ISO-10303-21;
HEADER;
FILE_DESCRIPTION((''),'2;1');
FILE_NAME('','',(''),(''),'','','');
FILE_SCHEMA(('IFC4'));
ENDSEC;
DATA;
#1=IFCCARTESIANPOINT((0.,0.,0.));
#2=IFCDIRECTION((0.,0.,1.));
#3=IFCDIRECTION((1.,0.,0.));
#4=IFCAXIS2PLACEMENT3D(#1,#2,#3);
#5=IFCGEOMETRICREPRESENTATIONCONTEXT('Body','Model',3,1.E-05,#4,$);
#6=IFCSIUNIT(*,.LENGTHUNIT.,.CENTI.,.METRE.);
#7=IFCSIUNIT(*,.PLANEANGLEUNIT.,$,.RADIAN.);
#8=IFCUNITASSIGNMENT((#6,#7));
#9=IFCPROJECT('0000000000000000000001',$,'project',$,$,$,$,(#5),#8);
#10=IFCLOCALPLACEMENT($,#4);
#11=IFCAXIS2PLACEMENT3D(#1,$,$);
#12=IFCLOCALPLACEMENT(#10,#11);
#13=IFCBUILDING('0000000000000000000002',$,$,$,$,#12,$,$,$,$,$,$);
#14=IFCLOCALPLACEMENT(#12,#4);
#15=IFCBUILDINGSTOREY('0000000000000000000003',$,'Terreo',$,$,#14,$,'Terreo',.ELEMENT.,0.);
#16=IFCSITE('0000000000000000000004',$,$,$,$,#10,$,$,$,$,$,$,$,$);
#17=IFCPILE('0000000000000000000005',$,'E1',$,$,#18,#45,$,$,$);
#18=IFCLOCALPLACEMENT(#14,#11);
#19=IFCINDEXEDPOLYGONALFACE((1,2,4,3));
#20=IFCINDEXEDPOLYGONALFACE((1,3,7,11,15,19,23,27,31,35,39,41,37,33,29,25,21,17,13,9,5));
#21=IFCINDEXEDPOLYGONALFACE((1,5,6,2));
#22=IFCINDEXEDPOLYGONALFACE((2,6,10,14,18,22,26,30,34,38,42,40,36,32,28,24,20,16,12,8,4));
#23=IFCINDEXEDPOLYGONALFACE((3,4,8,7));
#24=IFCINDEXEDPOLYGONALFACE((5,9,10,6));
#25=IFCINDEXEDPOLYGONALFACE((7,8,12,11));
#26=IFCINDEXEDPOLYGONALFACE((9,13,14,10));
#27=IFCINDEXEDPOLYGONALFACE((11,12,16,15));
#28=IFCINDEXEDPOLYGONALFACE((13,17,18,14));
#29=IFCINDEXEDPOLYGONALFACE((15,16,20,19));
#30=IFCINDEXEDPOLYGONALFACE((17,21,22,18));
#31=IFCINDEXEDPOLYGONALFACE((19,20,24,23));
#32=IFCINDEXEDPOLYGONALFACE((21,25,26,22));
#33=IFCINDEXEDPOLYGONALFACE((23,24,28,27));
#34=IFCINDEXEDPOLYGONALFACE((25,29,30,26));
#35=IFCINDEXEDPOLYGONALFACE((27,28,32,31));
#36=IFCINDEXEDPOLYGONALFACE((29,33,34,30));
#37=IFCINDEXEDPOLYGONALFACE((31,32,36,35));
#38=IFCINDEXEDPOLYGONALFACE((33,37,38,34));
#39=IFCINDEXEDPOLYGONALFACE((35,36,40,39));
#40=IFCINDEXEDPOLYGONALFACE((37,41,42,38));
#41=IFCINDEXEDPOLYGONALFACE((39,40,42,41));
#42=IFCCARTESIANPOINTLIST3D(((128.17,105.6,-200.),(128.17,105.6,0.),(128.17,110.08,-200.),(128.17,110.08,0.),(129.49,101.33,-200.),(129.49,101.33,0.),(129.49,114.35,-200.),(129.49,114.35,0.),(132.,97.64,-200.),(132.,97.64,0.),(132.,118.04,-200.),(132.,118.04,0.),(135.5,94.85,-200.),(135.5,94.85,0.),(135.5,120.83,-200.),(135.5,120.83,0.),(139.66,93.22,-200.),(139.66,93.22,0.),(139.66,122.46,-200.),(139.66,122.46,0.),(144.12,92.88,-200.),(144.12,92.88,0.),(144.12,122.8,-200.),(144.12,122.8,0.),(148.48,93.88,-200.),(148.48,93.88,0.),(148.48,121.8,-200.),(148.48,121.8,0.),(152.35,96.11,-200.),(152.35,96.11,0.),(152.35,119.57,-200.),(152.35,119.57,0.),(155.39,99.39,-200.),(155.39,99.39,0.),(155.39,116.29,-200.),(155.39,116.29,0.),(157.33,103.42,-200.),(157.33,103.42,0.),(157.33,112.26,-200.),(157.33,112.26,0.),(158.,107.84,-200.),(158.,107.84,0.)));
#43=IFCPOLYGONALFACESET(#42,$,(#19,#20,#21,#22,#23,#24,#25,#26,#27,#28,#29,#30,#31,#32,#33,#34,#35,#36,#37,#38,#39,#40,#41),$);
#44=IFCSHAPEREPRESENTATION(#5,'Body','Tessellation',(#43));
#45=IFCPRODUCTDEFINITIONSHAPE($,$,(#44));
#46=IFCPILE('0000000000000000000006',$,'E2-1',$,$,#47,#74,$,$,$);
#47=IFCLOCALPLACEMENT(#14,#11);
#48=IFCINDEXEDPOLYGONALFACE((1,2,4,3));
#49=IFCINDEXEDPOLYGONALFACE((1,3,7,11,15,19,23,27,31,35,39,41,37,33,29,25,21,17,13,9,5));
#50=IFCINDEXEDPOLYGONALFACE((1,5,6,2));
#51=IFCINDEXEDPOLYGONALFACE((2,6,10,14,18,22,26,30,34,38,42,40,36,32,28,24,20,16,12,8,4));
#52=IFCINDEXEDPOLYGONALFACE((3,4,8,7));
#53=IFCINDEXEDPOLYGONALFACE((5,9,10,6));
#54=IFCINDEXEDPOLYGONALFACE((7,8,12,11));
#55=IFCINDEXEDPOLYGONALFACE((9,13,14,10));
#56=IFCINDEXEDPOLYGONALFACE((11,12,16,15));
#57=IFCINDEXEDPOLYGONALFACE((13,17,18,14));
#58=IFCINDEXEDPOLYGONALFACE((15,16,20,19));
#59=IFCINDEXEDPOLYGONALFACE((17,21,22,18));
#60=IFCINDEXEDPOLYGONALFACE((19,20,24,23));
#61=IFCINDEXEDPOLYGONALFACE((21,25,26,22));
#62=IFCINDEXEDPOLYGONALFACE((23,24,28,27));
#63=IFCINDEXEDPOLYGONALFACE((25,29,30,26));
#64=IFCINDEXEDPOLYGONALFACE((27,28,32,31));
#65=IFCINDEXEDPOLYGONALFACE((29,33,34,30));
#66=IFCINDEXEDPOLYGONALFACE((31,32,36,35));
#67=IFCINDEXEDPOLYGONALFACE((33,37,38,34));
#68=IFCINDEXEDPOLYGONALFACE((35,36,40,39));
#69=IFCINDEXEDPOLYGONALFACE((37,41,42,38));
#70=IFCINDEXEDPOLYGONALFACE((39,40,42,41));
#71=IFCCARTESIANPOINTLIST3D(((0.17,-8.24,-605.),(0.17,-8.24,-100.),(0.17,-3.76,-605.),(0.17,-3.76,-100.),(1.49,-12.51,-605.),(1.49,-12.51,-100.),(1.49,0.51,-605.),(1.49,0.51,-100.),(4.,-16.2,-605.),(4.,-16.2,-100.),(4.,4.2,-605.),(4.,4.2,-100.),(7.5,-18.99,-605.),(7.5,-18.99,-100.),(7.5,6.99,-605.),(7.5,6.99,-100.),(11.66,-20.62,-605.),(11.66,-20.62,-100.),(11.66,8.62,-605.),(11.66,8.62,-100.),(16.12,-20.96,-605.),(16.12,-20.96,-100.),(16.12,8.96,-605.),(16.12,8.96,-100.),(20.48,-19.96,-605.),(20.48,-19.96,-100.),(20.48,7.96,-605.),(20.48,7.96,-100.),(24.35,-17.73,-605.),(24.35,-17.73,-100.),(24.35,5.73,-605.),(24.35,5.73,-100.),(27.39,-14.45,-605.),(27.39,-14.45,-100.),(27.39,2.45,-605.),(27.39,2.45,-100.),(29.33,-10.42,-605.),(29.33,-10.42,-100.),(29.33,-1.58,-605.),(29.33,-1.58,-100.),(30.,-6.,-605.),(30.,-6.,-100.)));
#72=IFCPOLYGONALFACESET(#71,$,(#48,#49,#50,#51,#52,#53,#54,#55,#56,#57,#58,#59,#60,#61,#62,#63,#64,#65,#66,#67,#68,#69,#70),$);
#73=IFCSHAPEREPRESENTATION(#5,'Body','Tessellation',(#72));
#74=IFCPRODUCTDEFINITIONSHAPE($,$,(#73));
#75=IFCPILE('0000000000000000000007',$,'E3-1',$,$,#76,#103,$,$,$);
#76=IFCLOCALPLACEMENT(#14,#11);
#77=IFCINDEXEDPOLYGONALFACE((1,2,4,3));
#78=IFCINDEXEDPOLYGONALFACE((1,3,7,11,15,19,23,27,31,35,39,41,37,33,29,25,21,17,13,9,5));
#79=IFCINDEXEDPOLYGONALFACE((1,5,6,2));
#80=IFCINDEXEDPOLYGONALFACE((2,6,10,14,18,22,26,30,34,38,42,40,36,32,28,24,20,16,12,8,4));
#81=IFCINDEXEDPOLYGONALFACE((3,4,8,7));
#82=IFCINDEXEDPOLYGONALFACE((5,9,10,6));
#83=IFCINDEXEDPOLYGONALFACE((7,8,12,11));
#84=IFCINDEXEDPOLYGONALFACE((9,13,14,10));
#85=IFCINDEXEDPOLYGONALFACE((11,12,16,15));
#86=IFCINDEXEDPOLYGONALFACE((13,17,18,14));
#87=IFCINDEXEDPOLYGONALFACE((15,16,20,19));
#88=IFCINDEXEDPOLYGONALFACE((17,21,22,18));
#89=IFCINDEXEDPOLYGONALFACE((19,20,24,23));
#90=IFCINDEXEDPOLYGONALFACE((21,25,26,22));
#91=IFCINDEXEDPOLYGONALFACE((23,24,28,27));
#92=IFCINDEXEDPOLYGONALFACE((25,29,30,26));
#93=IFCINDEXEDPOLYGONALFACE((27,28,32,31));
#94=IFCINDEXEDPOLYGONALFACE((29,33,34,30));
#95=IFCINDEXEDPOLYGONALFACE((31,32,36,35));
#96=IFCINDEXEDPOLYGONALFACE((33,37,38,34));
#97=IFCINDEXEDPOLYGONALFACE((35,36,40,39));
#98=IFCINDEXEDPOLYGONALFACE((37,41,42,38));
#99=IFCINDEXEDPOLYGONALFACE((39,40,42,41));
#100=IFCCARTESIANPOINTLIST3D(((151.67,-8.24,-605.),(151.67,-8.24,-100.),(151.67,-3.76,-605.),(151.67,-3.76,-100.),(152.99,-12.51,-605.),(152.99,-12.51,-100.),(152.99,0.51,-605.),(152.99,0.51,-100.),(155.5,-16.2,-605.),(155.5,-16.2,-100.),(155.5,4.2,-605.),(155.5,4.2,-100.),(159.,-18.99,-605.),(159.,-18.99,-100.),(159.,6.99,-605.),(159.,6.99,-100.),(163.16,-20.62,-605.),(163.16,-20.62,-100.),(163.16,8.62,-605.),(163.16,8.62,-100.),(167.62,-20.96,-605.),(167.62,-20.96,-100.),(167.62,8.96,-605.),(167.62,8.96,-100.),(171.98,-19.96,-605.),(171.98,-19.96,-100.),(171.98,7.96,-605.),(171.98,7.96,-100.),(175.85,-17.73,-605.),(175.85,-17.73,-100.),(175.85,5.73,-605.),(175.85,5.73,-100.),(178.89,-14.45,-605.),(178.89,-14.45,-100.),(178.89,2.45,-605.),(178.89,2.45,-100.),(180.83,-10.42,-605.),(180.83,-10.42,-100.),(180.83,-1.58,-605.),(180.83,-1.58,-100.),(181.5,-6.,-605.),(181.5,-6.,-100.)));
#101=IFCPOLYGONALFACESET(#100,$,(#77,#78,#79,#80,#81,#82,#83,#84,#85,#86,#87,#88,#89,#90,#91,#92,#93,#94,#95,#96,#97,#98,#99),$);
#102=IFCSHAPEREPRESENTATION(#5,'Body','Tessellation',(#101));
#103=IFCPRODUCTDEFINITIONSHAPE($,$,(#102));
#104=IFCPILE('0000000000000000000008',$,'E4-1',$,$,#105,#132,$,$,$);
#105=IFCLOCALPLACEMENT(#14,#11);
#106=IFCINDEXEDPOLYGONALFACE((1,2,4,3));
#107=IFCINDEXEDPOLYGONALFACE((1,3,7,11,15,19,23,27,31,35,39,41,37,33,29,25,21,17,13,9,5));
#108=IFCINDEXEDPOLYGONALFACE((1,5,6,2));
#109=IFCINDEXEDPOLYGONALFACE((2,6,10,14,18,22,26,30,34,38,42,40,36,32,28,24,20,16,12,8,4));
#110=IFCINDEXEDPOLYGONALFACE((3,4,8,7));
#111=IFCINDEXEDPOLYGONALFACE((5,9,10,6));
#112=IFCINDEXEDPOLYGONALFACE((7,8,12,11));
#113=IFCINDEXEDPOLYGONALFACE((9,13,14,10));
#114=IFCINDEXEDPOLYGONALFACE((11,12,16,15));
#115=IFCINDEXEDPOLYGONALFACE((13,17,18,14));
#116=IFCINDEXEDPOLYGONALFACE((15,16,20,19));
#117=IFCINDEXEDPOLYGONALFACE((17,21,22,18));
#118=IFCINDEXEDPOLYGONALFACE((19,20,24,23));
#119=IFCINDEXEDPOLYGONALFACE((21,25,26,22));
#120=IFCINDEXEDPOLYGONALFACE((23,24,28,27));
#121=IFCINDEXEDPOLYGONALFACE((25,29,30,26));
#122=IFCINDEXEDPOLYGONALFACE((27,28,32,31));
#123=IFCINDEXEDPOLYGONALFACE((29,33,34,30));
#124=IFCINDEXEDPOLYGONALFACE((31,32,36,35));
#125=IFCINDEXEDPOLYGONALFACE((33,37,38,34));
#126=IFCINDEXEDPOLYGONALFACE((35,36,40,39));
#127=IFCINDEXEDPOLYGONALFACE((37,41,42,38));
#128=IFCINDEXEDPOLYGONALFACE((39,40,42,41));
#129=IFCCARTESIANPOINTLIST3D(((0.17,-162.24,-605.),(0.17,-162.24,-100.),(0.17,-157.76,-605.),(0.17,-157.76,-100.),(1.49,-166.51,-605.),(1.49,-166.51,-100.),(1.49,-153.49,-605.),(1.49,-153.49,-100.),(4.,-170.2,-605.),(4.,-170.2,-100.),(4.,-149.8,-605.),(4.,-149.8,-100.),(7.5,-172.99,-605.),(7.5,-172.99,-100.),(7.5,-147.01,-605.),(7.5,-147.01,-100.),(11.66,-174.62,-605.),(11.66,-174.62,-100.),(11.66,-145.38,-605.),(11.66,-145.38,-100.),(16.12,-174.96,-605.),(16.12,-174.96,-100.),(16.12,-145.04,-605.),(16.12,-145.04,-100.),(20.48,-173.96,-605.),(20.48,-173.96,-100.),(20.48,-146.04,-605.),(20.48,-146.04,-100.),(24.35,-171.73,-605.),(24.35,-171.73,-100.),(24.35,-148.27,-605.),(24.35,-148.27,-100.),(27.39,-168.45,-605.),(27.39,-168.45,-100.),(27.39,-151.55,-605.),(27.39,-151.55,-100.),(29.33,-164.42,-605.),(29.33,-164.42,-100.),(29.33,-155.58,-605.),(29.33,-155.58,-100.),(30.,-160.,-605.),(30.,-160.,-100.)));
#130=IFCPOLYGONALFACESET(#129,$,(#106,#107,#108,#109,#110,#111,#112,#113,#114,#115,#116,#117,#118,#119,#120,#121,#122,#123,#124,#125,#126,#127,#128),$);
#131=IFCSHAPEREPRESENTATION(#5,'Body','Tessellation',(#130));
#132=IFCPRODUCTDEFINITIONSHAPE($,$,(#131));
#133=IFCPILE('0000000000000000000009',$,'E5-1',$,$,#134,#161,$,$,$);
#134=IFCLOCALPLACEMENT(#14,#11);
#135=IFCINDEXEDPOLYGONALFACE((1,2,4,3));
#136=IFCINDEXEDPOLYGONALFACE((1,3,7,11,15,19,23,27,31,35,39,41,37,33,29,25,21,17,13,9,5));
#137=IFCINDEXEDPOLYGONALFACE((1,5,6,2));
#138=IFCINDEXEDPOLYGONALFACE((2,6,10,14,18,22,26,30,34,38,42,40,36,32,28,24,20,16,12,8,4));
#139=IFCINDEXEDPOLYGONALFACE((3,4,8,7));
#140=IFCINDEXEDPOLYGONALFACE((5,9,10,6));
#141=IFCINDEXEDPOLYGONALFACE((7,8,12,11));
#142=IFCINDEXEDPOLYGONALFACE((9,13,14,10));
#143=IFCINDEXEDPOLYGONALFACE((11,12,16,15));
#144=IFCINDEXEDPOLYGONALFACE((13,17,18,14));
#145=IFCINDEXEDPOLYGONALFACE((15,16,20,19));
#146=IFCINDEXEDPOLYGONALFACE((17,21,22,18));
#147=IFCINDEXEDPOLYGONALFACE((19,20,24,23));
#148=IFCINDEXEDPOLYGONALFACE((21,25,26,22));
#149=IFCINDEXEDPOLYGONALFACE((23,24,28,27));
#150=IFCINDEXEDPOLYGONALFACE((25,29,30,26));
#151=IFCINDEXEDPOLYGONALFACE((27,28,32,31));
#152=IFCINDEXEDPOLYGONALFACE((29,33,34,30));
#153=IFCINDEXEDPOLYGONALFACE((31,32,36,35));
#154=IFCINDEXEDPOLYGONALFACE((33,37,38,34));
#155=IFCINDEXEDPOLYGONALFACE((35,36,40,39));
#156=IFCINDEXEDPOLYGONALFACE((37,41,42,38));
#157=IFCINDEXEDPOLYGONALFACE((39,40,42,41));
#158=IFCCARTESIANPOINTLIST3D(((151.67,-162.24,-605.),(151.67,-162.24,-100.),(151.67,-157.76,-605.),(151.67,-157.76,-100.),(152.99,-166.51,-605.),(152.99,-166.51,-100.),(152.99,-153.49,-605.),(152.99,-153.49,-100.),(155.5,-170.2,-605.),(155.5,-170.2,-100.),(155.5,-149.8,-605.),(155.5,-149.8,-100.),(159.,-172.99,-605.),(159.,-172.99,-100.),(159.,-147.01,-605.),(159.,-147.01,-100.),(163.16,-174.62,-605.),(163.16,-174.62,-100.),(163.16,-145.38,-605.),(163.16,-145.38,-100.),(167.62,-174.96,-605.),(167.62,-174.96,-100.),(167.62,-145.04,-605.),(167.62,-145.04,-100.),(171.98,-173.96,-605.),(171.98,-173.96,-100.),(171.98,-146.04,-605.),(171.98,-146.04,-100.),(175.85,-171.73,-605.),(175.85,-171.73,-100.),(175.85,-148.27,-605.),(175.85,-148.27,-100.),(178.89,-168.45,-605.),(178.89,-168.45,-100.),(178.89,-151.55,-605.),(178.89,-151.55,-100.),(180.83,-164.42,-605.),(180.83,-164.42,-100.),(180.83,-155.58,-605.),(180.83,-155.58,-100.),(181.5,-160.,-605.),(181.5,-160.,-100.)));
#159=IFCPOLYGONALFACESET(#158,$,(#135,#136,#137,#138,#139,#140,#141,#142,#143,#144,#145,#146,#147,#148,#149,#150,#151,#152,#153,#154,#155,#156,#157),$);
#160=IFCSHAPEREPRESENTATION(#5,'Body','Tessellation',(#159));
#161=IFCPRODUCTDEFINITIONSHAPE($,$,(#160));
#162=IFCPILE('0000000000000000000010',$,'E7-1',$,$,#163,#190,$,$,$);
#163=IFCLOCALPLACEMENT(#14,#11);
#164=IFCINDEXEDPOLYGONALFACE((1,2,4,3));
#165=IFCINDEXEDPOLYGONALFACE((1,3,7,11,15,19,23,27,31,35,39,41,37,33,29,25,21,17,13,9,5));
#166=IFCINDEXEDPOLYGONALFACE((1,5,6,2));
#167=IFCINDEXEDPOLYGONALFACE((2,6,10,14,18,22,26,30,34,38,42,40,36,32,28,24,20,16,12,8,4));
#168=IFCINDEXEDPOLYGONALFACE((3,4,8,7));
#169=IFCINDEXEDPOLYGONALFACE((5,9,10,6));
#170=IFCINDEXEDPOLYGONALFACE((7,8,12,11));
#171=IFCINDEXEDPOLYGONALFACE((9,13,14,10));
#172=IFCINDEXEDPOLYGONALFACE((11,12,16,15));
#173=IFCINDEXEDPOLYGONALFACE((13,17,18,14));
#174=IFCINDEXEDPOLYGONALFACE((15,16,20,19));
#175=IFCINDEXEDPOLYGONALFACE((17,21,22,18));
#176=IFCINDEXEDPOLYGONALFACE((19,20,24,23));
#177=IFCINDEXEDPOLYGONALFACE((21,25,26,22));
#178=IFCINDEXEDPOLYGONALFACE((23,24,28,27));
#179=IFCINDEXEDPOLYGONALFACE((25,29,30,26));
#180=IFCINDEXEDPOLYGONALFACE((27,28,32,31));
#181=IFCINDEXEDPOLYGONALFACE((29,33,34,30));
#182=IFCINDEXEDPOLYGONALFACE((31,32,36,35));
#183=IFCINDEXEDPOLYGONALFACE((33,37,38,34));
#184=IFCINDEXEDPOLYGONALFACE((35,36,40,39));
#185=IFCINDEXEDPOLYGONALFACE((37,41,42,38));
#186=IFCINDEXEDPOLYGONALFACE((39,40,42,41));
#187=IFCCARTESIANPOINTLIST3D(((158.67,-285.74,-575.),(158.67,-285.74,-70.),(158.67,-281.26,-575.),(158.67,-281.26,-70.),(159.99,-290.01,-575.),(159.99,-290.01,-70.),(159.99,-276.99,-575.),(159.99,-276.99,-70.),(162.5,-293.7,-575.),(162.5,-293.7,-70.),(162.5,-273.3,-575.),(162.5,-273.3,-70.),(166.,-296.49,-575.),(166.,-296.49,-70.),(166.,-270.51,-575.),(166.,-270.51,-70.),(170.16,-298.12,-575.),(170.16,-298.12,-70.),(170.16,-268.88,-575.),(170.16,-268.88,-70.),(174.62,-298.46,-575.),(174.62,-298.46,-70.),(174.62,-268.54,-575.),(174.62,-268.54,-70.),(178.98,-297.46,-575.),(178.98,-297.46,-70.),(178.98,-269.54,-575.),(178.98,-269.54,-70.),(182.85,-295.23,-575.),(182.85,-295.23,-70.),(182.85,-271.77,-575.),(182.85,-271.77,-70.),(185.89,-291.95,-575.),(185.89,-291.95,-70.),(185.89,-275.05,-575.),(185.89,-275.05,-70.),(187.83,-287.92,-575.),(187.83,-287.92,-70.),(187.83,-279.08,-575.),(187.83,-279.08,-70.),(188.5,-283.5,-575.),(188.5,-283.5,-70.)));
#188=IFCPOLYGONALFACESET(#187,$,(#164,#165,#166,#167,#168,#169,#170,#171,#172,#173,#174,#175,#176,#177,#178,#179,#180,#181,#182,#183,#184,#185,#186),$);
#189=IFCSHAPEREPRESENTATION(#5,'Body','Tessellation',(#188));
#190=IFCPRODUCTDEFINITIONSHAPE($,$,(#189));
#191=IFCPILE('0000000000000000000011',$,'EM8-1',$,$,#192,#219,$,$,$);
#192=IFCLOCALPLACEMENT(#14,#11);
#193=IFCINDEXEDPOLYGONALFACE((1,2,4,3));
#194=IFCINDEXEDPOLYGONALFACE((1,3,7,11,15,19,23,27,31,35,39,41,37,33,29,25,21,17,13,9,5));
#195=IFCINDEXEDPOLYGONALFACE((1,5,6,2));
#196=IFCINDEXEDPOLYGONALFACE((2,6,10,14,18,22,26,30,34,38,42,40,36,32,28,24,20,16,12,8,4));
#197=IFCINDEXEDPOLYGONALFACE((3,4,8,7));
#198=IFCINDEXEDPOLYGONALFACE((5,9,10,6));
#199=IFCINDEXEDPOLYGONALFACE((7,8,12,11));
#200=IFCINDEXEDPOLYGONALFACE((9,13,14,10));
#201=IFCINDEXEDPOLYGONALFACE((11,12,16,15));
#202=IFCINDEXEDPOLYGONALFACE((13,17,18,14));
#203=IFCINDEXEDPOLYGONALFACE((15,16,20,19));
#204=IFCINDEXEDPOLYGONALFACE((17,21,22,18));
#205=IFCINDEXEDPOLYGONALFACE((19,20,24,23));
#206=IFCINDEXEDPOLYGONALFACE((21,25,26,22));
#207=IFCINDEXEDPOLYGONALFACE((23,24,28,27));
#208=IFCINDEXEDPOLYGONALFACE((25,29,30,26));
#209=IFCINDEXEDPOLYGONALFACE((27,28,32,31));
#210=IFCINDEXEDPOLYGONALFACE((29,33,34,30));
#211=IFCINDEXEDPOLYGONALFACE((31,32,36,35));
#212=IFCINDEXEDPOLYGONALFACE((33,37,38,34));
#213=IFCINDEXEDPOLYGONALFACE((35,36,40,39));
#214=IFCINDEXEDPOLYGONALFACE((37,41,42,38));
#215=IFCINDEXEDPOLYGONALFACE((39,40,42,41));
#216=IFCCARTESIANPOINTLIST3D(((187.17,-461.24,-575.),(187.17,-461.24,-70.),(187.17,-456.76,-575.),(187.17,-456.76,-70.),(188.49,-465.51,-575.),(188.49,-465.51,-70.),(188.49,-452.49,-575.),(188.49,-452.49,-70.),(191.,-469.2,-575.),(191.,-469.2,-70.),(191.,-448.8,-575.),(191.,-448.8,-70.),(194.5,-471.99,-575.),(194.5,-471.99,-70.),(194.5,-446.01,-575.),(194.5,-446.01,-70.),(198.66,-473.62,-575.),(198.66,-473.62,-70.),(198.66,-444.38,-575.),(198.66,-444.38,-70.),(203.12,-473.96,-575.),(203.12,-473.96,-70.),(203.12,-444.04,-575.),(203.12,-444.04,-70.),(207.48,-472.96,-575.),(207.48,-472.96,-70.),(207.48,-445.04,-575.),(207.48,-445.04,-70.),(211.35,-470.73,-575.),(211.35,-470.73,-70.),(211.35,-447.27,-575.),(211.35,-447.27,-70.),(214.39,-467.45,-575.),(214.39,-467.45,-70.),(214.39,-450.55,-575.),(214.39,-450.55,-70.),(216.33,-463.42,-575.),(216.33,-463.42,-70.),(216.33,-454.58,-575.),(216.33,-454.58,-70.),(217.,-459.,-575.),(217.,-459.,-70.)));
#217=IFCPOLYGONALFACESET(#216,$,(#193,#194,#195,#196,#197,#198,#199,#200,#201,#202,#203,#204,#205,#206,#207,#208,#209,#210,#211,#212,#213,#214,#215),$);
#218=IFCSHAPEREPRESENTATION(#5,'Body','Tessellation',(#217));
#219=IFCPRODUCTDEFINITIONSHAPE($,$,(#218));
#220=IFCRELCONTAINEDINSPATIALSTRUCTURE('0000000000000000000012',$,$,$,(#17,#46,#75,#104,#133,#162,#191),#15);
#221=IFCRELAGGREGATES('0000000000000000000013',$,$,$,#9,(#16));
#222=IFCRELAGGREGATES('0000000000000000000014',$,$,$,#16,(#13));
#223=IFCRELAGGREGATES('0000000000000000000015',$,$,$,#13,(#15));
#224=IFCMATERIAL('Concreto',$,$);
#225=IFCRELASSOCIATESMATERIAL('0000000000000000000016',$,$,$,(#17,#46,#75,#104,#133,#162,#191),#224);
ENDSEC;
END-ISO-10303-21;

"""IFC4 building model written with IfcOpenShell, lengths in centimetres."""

from ifc_helpers import new_model, si_unit, frame, origin, origin_with_axes, origin_2d_with_axis, place, context, project, spatial, circle, extrude, material, element, save


model = new_model("IFC4")

# Units and contexts
model_context = context("Model", 3, precision=1e-05, world=origin_with_axes(), identifier="Body")
ifc_project = project(units=[si_unit("LENGTHUNIT", "METRE", prefix="CENTI"), si_unit("PLANEANGLEUNIT", "RADIAN")], contexts=[model_context])

# Site, building, storey
site_placement = place(None, origin_with_axes())
site = spatial("IfcSite", under=ifc_project, at=site_placement)
building_placement = place(site_placement, origin())
building = spatial("IfcBuilding", under=site, at=building_placement)
storey_placement = place(building_placement, origin_with_axes())
storey = spatial("IfcBuildingStorey", under=building, at=storey_placement, Name="Terreo", LongName="Terreo", CompositionType="ELEMENT", Elevation=0.0)

# Piles
ifc_material = material(Name="Concreto")
pile_placement = place(storey_placement, frame((143.0, 107.84, 0.0), z_axis=(0.0, 0.0, 1.0), x_axis=(1.0, 0.0, 0.0)))
element("IfcPile", 1, at=pile_placement, inside=storey, material=ifc_material, Name="E1", context=model_context, shape_type="SolidModel", body=[
    extrude(circle(Radius=15.0, at=origin_2d_with_axis()), frame((0.0, 0.0, -200.0), z_axis=(0.0, 0.0, 1.0), x_axis=(1.0, 0.0, 0.0)), (0.0, 0.0, 1.0), 200.0),
])
for number, where, z_axis, x_axis, name in (
    (2, (15.0, -6.0, -100.0), (0.0, 0.0, 1.0), (1.0, 0.0, 0.0), "E2-1"),
    (3, (166.5, -6.0, -100.0), (0.0, 0.0, 1.0), (1.0, 0.0, 0.0), "E3-1"),
    (4, (15.0, -160.0, -100.0), (0.0, 0.0, 1.0), (1.0, 0.0, 0.0), "E4-1"),
    (5, (166.5, -160.0, -100.0), (0.0, 0.0, 1.0), (1.0, 0.0, 0.0), "E5-1"),
    (6, (173.5, -283.5, -70.0), (0.0, 0.0, 1.0), (1.0, 0.0, 0.0), "E7-1"),
    (7, (202.0, -459.0, -70.0), (0.0, 0.0, 1.0), (1.0, 0.0, 0.0), "EM8-1"),
):
    element("IfcPile", number, at=place(storey_placement, frame(where, z_axis=z_axis, x_axis=x_axis)), inside=storey, material=ifc_material, Name=name, context=model_context, shape_type="SweptSolid", body=[
        extrude(circle(Radius=15.0, at=origin_2d_with_axis()), frame((0.0, 0.0, -505.0), z_axis=(0.0, 0.0, 1.0), x_axis=(1.0, 0.0, 0.0)), (0.0, 0.0, 1.0), 505.0),
    ])

save(model, "model.ifc")
